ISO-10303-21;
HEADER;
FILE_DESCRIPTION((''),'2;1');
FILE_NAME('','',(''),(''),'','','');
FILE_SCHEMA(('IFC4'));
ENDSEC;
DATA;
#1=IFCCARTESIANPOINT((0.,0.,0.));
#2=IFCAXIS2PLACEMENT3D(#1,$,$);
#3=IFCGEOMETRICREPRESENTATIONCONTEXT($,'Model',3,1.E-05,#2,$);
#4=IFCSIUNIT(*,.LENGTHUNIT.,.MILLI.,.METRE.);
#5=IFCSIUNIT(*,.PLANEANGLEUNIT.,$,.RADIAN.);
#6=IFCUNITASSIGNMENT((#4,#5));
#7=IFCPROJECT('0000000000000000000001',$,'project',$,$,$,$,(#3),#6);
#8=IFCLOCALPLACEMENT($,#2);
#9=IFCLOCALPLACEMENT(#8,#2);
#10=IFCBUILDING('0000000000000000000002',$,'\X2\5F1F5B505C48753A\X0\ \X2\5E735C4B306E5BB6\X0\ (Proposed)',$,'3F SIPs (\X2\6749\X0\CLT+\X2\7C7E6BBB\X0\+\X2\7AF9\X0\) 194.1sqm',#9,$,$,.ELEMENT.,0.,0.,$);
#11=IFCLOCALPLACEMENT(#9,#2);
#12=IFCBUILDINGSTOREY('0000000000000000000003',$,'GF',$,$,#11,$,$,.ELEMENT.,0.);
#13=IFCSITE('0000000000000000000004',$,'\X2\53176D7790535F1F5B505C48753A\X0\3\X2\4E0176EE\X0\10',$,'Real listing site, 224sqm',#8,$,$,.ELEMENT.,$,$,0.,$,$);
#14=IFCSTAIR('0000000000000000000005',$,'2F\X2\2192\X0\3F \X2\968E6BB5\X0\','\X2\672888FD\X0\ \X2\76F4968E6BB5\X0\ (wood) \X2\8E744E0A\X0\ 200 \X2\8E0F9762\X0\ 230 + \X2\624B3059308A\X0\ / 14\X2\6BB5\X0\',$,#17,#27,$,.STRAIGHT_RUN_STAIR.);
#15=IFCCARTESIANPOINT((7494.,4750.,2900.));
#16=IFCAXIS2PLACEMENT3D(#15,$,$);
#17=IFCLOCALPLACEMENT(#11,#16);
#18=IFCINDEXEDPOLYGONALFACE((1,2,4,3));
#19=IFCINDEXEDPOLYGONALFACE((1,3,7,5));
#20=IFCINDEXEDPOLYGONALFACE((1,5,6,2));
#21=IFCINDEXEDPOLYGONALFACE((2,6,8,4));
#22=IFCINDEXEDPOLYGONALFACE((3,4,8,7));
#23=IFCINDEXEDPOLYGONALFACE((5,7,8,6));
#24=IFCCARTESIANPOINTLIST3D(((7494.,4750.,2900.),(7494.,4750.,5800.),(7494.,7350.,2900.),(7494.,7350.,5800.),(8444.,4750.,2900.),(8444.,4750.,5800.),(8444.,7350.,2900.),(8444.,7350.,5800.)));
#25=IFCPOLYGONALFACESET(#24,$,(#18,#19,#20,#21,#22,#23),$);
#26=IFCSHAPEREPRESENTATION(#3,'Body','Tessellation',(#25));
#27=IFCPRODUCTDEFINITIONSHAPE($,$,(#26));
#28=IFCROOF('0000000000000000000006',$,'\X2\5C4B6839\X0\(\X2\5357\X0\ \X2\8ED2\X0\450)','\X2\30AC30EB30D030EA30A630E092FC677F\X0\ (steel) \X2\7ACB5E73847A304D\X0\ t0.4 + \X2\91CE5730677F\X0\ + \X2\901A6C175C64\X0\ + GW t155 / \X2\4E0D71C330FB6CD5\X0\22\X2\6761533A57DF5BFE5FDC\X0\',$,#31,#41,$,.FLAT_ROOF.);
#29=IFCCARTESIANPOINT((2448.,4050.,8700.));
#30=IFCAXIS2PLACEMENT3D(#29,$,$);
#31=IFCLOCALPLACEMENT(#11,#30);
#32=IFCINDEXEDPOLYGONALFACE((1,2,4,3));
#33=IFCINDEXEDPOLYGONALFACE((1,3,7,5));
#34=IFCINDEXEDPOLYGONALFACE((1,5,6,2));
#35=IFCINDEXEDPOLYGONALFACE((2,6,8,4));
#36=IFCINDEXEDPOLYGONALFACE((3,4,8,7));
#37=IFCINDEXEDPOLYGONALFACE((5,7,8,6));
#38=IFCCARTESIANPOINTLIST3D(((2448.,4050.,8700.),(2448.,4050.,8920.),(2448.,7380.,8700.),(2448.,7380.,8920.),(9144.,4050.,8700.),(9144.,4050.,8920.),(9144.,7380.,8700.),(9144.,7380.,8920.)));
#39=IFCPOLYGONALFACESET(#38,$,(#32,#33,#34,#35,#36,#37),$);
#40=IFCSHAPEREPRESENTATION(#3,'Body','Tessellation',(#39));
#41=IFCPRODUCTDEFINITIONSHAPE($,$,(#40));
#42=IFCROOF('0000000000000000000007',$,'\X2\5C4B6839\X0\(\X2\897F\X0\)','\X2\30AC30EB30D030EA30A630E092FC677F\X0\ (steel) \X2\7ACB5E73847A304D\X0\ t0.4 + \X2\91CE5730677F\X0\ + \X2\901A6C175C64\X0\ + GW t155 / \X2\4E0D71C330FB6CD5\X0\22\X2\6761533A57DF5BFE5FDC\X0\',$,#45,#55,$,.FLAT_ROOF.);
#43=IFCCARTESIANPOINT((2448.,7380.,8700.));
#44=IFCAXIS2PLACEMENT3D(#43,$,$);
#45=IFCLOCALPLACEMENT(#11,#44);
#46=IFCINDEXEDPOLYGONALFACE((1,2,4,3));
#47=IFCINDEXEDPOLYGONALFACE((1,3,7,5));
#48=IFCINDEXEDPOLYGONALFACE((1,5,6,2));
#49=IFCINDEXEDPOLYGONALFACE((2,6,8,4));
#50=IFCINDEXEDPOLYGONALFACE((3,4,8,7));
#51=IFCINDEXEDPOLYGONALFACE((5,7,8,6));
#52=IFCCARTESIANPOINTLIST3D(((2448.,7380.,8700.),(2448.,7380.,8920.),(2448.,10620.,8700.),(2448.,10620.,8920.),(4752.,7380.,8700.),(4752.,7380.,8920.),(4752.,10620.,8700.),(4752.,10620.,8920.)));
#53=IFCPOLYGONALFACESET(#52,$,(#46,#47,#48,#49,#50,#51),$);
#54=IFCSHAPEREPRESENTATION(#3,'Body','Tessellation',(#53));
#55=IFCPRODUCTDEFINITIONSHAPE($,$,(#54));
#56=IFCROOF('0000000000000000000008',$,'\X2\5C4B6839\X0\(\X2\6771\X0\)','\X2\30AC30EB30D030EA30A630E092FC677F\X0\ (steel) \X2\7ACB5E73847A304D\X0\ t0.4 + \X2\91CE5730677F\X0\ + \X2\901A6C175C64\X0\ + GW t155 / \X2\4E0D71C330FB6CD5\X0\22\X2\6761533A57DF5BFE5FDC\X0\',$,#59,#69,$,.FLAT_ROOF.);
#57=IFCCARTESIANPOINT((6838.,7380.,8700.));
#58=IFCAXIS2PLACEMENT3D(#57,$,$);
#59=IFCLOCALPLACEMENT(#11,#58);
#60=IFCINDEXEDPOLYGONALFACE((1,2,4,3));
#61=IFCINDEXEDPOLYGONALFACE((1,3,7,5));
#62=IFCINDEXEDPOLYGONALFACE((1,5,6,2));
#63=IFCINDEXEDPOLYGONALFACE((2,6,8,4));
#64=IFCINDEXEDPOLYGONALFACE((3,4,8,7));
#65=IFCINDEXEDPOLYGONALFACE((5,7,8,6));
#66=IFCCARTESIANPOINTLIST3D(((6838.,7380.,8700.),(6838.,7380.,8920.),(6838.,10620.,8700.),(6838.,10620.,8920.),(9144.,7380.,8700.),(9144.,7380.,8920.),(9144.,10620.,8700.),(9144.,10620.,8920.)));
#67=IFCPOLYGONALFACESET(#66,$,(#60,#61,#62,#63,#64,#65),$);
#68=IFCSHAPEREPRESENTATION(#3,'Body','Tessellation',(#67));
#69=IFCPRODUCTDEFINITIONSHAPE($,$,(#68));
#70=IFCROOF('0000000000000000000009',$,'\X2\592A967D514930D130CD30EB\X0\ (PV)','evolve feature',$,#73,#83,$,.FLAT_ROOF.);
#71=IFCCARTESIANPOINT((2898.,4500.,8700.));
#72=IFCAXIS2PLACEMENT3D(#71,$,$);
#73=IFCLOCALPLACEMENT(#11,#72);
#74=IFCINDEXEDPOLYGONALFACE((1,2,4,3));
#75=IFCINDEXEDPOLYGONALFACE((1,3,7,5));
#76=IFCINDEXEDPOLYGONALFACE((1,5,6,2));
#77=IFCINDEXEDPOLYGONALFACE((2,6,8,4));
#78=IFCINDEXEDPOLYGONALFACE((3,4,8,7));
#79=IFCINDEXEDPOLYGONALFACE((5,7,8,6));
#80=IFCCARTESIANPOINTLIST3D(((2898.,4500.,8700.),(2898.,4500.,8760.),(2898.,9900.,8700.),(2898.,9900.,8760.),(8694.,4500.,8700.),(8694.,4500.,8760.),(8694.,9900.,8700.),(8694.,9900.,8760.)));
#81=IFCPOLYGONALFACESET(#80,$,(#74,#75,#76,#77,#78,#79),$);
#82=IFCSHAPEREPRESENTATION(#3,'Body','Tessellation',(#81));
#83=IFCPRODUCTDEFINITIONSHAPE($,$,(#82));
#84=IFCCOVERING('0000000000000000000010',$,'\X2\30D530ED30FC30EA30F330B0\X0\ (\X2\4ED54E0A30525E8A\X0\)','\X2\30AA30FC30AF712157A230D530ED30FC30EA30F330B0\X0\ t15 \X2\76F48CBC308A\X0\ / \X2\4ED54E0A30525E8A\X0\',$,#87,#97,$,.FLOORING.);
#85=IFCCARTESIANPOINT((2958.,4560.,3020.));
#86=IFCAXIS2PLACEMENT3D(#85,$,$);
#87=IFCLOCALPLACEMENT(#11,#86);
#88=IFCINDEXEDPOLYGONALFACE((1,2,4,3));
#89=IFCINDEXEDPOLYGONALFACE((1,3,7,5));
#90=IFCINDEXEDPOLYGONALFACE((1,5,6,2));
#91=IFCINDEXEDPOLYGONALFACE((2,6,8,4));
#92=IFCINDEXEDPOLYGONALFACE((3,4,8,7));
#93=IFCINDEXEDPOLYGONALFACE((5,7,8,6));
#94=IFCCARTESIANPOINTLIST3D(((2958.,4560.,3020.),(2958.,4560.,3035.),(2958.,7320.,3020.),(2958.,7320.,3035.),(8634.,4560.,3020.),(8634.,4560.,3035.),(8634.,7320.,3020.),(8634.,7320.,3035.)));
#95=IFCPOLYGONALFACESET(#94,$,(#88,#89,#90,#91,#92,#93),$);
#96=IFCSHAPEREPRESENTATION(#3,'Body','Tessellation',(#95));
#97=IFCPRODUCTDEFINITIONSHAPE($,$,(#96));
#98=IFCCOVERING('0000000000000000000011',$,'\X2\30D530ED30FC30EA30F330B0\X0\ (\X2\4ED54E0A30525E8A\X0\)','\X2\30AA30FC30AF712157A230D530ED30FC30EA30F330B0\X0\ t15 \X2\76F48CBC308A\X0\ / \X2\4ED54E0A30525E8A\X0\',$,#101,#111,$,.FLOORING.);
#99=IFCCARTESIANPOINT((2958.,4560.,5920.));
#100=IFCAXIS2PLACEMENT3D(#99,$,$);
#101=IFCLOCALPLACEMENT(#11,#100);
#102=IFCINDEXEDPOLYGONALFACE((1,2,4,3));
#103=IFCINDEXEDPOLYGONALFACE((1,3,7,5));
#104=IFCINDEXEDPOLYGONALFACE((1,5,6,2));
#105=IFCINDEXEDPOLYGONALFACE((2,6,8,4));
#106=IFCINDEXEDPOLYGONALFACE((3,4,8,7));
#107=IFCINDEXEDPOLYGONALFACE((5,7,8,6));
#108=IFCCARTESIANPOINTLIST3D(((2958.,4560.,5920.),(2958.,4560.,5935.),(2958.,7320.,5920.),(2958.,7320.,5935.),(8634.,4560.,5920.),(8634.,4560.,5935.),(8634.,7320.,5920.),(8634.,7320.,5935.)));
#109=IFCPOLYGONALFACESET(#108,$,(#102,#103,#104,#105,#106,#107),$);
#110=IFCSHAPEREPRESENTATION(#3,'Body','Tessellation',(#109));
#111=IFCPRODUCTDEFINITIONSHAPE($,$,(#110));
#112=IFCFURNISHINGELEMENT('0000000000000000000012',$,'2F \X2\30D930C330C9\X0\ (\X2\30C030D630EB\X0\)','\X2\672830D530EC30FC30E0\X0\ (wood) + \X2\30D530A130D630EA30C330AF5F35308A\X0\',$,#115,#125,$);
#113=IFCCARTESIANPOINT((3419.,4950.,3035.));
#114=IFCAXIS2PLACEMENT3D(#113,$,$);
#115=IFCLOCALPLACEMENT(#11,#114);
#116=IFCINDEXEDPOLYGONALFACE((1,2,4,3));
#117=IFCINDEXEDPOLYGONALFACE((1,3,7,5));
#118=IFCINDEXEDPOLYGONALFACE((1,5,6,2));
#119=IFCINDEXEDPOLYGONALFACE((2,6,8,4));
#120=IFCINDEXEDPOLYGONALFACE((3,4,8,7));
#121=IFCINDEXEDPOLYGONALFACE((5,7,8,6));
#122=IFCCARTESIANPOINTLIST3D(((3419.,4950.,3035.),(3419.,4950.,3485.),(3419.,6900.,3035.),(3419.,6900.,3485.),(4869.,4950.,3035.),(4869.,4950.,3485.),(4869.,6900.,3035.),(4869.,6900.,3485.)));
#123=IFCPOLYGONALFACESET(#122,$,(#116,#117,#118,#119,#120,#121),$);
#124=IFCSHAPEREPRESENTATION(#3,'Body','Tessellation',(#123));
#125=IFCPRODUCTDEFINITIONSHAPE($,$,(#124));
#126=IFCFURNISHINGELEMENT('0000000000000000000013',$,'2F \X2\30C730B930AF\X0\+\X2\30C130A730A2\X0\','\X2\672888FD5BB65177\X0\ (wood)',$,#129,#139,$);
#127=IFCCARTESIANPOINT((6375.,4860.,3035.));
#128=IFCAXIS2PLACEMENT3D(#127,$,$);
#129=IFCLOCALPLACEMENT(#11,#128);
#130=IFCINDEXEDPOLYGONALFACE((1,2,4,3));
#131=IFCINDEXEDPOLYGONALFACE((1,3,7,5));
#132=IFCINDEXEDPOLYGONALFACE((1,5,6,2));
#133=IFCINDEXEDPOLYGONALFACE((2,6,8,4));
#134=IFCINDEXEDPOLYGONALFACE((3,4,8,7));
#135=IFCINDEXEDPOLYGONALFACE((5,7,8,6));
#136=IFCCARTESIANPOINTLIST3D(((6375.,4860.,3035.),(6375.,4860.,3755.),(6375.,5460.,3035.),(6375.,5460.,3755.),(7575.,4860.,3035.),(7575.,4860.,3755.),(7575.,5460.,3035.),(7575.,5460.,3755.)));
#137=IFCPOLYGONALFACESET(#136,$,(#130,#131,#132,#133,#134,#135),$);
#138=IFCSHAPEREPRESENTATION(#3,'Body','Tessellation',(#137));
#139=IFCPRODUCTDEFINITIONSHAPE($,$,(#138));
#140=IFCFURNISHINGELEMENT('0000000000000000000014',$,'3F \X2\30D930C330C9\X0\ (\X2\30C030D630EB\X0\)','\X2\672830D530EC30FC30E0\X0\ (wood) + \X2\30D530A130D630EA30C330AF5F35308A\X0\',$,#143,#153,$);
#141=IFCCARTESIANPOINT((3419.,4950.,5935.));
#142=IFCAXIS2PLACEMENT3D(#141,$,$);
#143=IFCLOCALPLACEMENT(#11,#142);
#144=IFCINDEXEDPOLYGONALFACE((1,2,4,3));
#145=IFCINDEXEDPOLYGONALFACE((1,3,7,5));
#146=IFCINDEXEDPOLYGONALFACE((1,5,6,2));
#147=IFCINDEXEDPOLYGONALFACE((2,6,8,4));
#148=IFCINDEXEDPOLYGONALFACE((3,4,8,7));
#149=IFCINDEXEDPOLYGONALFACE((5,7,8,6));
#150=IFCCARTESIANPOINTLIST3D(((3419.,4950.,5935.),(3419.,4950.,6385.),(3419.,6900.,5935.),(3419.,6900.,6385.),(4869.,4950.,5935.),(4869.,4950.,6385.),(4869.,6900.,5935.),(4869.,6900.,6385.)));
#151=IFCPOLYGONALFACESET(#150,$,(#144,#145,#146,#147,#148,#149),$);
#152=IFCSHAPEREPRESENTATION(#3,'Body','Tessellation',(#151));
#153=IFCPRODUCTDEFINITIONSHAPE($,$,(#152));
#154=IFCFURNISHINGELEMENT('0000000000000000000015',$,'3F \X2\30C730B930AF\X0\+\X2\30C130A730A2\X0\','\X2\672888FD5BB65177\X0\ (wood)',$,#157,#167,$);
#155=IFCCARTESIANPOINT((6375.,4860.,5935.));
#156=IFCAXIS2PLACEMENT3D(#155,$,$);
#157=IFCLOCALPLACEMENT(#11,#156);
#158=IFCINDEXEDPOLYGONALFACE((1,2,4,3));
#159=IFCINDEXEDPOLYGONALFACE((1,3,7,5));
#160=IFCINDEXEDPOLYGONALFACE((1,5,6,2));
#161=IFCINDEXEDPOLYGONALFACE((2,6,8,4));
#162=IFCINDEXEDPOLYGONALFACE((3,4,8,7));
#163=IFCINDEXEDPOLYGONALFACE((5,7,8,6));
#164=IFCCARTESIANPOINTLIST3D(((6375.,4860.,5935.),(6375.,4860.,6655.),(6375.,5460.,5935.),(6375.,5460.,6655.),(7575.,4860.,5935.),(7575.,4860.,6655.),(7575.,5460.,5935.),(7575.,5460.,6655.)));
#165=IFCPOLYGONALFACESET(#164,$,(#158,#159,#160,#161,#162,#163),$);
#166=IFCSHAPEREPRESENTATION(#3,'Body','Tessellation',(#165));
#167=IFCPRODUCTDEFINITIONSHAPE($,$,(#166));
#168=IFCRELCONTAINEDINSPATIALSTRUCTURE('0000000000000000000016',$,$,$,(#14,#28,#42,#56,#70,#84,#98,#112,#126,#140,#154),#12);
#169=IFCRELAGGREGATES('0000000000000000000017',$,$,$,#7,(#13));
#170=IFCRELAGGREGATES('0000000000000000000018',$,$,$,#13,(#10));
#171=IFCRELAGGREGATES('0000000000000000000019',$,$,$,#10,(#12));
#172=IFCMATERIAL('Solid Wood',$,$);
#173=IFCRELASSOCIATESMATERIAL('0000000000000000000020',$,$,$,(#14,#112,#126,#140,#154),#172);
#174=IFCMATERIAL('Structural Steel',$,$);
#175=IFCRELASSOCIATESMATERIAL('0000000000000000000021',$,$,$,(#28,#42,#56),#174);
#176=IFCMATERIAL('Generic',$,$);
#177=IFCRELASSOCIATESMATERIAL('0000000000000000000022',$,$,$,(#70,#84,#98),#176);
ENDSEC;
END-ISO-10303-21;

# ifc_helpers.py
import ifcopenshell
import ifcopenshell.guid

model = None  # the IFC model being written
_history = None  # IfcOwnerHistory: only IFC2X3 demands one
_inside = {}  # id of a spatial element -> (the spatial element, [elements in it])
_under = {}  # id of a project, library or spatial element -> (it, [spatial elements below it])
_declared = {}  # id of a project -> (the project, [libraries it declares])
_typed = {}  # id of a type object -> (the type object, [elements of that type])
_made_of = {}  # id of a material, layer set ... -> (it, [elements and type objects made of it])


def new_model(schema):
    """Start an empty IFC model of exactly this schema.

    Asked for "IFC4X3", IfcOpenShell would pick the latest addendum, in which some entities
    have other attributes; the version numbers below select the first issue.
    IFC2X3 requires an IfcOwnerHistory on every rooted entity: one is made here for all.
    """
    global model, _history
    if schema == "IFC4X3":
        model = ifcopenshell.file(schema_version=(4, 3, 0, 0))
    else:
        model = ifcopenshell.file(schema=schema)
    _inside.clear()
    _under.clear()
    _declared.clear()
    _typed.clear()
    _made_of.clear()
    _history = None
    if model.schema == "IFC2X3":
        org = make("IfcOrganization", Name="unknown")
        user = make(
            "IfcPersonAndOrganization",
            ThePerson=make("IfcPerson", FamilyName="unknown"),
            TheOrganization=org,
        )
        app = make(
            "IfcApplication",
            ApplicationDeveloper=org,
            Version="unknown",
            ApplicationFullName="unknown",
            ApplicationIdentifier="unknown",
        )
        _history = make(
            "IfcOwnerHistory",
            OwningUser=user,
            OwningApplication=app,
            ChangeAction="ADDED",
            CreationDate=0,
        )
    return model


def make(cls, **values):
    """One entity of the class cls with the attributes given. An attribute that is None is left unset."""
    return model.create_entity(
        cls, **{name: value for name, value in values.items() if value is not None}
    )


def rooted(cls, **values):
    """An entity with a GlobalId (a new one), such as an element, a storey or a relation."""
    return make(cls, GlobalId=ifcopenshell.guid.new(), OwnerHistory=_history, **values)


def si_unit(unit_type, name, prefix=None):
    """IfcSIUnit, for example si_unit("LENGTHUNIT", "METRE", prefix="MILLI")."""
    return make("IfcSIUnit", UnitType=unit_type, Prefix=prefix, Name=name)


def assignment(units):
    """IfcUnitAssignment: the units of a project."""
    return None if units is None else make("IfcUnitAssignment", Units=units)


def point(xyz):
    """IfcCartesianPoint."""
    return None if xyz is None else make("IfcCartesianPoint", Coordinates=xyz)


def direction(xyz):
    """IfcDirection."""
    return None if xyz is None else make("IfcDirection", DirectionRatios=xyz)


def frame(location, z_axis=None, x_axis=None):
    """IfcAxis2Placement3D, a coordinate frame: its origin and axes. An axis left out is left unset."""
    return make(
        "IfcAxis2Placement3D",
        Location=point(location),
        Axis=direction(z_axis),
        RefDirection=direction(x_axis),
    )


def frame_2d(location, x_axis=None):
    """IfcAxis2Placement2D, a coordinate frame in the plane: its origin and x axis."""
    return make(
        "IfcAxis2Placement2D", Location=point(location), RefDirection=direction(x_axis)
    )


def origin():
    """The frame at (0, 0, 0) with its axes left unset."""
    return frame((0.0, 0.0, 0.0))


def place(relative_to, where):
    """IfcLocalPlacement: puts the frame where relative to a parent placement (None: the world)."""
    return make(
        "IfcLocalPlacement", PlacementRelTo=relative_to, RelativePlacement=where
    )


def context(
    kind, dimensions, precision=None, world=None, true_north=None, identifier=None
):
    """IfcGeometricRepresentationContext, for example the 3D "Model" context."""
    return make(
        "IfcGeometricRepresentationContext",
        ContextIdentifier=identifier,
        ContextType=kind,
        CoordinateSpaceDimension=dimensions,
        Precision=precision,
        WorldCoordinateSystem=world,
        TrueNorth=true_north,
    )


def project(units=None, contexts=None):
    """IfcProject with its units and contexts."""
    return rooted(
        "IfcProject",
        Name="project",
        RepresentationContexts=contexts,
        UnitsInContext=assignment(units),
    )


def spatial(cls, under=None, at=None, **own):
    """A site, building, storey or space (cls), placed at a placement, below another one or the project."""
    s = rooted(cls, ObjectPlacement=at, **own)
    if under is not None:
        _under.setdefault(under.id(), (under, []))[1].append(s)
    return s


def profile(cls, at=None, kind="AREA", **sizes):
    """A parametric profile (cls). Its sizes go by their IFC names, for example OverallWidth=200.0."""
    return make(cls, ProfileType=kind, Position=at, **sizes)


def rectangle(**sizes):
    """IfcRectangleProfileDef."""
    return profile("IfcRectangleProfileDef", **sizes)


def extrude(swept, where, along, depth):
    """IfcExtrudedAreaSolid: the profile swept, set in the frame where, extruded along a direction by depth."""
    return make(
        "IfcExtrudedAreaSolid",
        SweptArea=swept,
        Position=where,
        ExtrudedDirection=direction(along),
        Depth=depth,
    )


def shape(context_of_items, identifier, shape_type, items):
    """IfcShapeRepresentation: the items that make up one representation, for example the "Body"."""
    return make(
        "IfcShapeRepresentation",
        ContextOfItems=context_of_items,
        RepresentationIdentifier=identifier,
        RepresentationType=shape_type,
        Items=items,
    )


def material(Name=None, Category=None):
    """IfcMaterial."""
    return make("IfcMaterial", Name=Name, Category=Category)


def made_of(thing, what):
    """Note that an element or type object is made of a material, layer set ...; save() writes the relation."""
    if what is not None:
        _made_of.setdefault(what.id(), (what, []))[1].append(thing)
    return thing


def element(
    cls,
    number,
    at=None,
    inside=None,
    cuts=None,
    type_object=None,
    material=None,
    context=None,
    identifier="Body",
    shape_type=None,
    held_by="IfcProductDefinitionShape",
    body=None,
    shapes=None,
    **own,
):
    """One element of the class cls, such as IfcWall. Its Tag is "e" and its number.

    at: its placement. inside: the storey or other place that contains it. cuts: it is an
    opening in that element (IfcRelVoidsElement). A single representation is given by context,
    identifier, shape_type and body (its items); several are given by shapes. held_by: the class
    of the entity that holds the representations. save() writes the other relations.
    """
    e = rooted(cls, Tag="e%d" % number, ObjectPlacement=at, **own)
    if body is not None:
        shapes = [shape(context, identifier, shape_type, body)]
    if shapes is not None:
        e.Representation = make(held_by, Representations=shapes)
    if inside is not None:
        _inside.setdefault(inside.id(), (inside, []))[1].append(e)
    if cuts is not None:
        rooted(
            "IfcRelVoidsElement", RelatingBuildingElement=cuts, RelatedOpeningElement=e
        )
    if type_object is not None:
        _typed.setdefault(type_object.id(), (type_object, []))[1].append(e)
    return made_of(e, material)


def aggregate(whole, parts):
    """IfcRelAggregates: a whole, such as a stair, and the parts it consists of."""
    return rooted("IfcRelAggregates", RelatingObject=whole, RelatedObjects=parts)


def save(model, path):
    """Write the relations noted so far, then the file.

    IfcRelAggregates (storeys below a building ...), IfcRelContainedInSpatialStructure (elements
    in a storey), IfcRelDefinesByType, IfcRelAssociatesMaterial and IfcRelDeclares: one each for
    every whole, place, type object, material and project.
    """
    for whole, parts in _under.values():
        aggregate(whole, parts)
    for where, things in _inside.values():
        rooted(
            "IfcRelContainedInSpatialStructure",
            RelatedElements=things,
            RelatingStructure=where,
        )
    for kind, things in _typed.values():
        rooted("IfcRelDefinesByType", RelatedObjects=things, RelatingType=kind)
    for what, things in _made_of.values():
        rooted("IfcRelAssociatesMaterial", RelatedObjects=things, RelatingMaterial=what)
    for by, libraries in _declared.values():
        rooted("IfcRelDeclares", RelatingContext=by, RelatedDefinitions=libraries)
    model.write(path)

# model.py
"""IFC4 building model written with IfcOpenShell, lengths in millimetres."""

from ifc_helpers import new_model, si_unit, frame, frame_2d, origin, place, context, project, spatial, rectangle, extrude, material, element, save


model = new_model("IFC4")

# Units and contexts
model_context = context("Model", 3, precision=1e-05, world=origin())
ifc_project = project(units=[si_unit("LENGTHUNIT", "METRE", prefix="MILLI"), si_unit("PLANEANGLEUNIT", "RADIAN")], contexts=[model_context])

# Site, building, storey
site_placement = place(None, origin())
site = spatial("IfcSite", under=ifc_project, at=site_placement, Name="北海道弟子屈町3丁目10", ObjectType="Real listing site, 224sqm", CompositionType="ELEMENT", RefElevation=0.0)
building_placement = place(site_placement, origin())
building = spatial("IfcBuilding", under=site, at=building_placement, Name="弟子屈町 平屋の家 (Proposed)", ObjectType="3F SIPs (杉CLT+籾殻+竹) 194.1sqm", CompositionType="ELEMENT", ElevationOfRefHeight=0.0, ElevationOfTerrain=0.0)
storey_placement = place(building_placement, origin())
storey = spatial("IfcBuildingStorey", under=building, at=storey_placement, Name="GF", CompositionType="ELEMENT", Elevation=0.0)

# Shared definitions
ifc_material_1 = material(Name="Solid Wood")

# Stair
stair_placement = place(storey_placement, frame((7494.0, 4750.0, 2900.0)))
element("IfcStair", 1, at=stair_placement, inside=storey, material=ifc_material_1, Name="2F→3F 階段", Description="木製 直階段 (wood) 蹴上 200 踏面 230 + 手すり / 14段", PredefinedType="STRAIGHT_RUN_STAIR", context=model_context, shape_type="SweptSolid", body=[
    extrude(rectangle(XDim=950.0, YDim=2600.0, at=frame_2d((475.0, 1300.0))), frame((7494.0, 4750.0, 2900.0)), (0.0, 0.0, 1.0), 2900.0),
])

# Roofs
ifc_material_2 = material(Name="Structural Steel")
roof_1_placement = place(storey_placement, frame((2448.0, 4050.0, 8700.0)))
element("IfcRoof", 2, at=roof_1_placement, inside=storey, material=ifc_material_2, Name="屋根(南 軒450)", Description="ガルバリウム鋼板 (steel) 立平葺き t0.4 + 野地板 + 通気層 + GW t155 / 不燃・法22条区域対応", PredefinedType="FLAT_ROOF", context=model_context, shape_type="SweptSolid", body=[
    extrude(rectangle(XDim=6696.0, YDim=3330.0, at=frame_2d((3348.0, 1665.0))), frame((2448.0, 4050.0, 8700.0)), (0.0, 0.0, 1.0), 220.0),
])
roof_2_placement = place(storey_placement, frame((2448.0, 7380.0, 8700.0)))
element("IfcRoof", 3, at=roof_2_placement, inside=storey, material=ifc_material_2, Name="屋根(西)", Description="ガルバリウム鋼板 (steel) 立平葺き t0.4 + 野地板 + 通気層 + GW t155 / 不燃・法22条区域対応", PredefinedType="FLAT_ROOF", context=model_context, shape_type="SweptSolid", body=[
    extrude(rectangle(XDim=2304.0, YDim=3240.0, at=frame_2d((1152.0, 1620.0))), frame((2448.0, 7380.0, 8700.0)), (0.0, 0.0, 1.0), 220.0),
])
roof_3_placement = place(storey_placement, frame((6838.0, 7380.0, 8700.0)))
element("IfcRoof", 4, at=roof_3_placement, inside=storey, material=ifc_material_2, Name="屋根(東)", Description="ガルバリウム鋼板 (steel) 立平葺き t0.4 + 野地板 + 通気層 + GW t155 / 不燃・法22条区域対応", PredefinedType="FLAT_ROOF", context=model_context, shape_type="SweptSolid", body=[
    extrude(rectangle(XDim=2306.0, YDim=3240.0, at=frame_2d((1153.0, 1620.0))), frame((6838.0, 7380.0, 8700.0)), (0.0, 0.0, 1.0), 220.0),
])
ifc_material_3 = material(Name="Generic")
roof_4_placement = place(storey_placement, frame((2898.0, 4500.0, 8700.0)))
element("IfcRoof", 5, at=roof_4_placement, inside=storey, material=ifc_material_3, Name="太陽光パネル (PV)", Description="evolve feature", PredefinedType="FLAT_ROOF", context=model_context, shape_type="SweptSolid", body=[
    extrude(rectangle(XDim=5796.0, YDim=5400.0, at=frame_2d((2898.0, 2700.0))), frame((2898.0, 4500.0, 8700.0)), (0.0, 0.0, 1.0), 60.0),
])

# Coverings
covering_1_placement = place(storey_placement, frame((2958.0, 4560.0, 3020.0)))
element("IfcCovering", 6, at=covering_1_placement, inside=storey, material=ifc_material_3, Name="フローリング (仕上げ床)", Description="オーク無垢フローリング t15 直貼り / 仕上げ床", PredefinedType="FLOORING", context=model_context, shape_type="SweptSolid", body=[
    extrude(rectangle(XDim=5676.0, YDim=2760.0, at=frame_2d((2838.0, 1380.0))), frame((2958.0, 4560.0, 3020.0)), (0.0, 0.0, 1.0), 15.0),
])
covering_2_placement = place(storey_placement, frame((2958.0, 4560.0, 5920.0)))
element("IfcCovering", 7, at=covering_2_placement, inside=storey, material=ifc_material_3, Name="フローリング (仕上げ床)", Description="オーク無垢フローリング t15 直貼り / 仕上げ床", PredefinedType="FLOORING", context=model_context, shape_type="SweptSolid", body=[
    extrude(rectangle(XDim=5676.0, YDim=2760.0, at=frame_2d((2838.0, 1380.0))), frame((2958.0, 4560.0, 5920.0)), (0.0, 0.0, 1.0), 15.0),
])

# Furnishing elements
furnishing_1_placement = place(storey_placement, frame((3419.0, 4950.0, 3035.0)))
element("IfcFurnishingElement", 8, at=furnishing_1_placement, inside=storey, material=ifc_material_1, Name="2F ベッド (ダブル)", Description="木フレーム (wood) + ファブリック張り", context=model_context, shape_type="SweptSolid", body=[
    extrude(rectangle(XDim=1450.0, YDim=1950.0, at=frame_2d((725.0, 975.0))), frame((3419.0, 4950.0, 3035.0)), (0.0, 0.0, 1.0), 450.0),
])
furnishing_2_placement = place(storey_placement, frame((6375.0, 4860.0, 3035.0)))
element("IfcFurnishingElement", 9, at=furnishing_2_placement, inside=storey, material=ifc_material_1, Name="2F デスク+チェア", Description="木製家具 (wood)", context=model_context, shape_type="SweptSolid", body=[
    extrude(rectangle(XDim=1200.0, YDim=600.0, at=frame_2d((600.0, 300.0))), frame((6375.0, 4860.0, 3035.0)), (0.0, 0.0, 1.0), 720.0),
])
furnishing_3_placement = place(storey_placement, frame((3419.0, 4950.0, 5935.0)))
element("IfcFurnishingElement", 10, at=furnishing_3_placement, inside=storey, material=ifc_material_1, Name="3F ベッド (ダブル)", Description="木フレーム (wood) + ファブリック張り", context=model_context, shape_type="SweptSolid", body=[
    extrude(rectangle(XDim=1450.0, YDim=1950.0, at=frame_2d((725.0, 975.0))), frame((3419.0, 4950.0, 5935.0)), (0.0, 0.0, 1.0), 450.0),
])
furnishing_4_placement = place(storey_placement, frame((6375.0, 4860.0, 5935.0)))
element("IfcFurnishingElement", 11, at=furnishing_4_placement, inside=storey, material=ifc_material_1, Name="3F デスク+チェア", Description="木製家具 (wood)", context=model_context, shape_type="SweptSolid", body=[
    extrude(rectangle(XDim=1200.0, YDim=600.0, at=frame_2d((600.0, 300.0))), frame((6375.0, 4860.0, 5935.0)), (0.0, 0.0, 1.0), 720.0),
])

save(model, "model.ifc")
